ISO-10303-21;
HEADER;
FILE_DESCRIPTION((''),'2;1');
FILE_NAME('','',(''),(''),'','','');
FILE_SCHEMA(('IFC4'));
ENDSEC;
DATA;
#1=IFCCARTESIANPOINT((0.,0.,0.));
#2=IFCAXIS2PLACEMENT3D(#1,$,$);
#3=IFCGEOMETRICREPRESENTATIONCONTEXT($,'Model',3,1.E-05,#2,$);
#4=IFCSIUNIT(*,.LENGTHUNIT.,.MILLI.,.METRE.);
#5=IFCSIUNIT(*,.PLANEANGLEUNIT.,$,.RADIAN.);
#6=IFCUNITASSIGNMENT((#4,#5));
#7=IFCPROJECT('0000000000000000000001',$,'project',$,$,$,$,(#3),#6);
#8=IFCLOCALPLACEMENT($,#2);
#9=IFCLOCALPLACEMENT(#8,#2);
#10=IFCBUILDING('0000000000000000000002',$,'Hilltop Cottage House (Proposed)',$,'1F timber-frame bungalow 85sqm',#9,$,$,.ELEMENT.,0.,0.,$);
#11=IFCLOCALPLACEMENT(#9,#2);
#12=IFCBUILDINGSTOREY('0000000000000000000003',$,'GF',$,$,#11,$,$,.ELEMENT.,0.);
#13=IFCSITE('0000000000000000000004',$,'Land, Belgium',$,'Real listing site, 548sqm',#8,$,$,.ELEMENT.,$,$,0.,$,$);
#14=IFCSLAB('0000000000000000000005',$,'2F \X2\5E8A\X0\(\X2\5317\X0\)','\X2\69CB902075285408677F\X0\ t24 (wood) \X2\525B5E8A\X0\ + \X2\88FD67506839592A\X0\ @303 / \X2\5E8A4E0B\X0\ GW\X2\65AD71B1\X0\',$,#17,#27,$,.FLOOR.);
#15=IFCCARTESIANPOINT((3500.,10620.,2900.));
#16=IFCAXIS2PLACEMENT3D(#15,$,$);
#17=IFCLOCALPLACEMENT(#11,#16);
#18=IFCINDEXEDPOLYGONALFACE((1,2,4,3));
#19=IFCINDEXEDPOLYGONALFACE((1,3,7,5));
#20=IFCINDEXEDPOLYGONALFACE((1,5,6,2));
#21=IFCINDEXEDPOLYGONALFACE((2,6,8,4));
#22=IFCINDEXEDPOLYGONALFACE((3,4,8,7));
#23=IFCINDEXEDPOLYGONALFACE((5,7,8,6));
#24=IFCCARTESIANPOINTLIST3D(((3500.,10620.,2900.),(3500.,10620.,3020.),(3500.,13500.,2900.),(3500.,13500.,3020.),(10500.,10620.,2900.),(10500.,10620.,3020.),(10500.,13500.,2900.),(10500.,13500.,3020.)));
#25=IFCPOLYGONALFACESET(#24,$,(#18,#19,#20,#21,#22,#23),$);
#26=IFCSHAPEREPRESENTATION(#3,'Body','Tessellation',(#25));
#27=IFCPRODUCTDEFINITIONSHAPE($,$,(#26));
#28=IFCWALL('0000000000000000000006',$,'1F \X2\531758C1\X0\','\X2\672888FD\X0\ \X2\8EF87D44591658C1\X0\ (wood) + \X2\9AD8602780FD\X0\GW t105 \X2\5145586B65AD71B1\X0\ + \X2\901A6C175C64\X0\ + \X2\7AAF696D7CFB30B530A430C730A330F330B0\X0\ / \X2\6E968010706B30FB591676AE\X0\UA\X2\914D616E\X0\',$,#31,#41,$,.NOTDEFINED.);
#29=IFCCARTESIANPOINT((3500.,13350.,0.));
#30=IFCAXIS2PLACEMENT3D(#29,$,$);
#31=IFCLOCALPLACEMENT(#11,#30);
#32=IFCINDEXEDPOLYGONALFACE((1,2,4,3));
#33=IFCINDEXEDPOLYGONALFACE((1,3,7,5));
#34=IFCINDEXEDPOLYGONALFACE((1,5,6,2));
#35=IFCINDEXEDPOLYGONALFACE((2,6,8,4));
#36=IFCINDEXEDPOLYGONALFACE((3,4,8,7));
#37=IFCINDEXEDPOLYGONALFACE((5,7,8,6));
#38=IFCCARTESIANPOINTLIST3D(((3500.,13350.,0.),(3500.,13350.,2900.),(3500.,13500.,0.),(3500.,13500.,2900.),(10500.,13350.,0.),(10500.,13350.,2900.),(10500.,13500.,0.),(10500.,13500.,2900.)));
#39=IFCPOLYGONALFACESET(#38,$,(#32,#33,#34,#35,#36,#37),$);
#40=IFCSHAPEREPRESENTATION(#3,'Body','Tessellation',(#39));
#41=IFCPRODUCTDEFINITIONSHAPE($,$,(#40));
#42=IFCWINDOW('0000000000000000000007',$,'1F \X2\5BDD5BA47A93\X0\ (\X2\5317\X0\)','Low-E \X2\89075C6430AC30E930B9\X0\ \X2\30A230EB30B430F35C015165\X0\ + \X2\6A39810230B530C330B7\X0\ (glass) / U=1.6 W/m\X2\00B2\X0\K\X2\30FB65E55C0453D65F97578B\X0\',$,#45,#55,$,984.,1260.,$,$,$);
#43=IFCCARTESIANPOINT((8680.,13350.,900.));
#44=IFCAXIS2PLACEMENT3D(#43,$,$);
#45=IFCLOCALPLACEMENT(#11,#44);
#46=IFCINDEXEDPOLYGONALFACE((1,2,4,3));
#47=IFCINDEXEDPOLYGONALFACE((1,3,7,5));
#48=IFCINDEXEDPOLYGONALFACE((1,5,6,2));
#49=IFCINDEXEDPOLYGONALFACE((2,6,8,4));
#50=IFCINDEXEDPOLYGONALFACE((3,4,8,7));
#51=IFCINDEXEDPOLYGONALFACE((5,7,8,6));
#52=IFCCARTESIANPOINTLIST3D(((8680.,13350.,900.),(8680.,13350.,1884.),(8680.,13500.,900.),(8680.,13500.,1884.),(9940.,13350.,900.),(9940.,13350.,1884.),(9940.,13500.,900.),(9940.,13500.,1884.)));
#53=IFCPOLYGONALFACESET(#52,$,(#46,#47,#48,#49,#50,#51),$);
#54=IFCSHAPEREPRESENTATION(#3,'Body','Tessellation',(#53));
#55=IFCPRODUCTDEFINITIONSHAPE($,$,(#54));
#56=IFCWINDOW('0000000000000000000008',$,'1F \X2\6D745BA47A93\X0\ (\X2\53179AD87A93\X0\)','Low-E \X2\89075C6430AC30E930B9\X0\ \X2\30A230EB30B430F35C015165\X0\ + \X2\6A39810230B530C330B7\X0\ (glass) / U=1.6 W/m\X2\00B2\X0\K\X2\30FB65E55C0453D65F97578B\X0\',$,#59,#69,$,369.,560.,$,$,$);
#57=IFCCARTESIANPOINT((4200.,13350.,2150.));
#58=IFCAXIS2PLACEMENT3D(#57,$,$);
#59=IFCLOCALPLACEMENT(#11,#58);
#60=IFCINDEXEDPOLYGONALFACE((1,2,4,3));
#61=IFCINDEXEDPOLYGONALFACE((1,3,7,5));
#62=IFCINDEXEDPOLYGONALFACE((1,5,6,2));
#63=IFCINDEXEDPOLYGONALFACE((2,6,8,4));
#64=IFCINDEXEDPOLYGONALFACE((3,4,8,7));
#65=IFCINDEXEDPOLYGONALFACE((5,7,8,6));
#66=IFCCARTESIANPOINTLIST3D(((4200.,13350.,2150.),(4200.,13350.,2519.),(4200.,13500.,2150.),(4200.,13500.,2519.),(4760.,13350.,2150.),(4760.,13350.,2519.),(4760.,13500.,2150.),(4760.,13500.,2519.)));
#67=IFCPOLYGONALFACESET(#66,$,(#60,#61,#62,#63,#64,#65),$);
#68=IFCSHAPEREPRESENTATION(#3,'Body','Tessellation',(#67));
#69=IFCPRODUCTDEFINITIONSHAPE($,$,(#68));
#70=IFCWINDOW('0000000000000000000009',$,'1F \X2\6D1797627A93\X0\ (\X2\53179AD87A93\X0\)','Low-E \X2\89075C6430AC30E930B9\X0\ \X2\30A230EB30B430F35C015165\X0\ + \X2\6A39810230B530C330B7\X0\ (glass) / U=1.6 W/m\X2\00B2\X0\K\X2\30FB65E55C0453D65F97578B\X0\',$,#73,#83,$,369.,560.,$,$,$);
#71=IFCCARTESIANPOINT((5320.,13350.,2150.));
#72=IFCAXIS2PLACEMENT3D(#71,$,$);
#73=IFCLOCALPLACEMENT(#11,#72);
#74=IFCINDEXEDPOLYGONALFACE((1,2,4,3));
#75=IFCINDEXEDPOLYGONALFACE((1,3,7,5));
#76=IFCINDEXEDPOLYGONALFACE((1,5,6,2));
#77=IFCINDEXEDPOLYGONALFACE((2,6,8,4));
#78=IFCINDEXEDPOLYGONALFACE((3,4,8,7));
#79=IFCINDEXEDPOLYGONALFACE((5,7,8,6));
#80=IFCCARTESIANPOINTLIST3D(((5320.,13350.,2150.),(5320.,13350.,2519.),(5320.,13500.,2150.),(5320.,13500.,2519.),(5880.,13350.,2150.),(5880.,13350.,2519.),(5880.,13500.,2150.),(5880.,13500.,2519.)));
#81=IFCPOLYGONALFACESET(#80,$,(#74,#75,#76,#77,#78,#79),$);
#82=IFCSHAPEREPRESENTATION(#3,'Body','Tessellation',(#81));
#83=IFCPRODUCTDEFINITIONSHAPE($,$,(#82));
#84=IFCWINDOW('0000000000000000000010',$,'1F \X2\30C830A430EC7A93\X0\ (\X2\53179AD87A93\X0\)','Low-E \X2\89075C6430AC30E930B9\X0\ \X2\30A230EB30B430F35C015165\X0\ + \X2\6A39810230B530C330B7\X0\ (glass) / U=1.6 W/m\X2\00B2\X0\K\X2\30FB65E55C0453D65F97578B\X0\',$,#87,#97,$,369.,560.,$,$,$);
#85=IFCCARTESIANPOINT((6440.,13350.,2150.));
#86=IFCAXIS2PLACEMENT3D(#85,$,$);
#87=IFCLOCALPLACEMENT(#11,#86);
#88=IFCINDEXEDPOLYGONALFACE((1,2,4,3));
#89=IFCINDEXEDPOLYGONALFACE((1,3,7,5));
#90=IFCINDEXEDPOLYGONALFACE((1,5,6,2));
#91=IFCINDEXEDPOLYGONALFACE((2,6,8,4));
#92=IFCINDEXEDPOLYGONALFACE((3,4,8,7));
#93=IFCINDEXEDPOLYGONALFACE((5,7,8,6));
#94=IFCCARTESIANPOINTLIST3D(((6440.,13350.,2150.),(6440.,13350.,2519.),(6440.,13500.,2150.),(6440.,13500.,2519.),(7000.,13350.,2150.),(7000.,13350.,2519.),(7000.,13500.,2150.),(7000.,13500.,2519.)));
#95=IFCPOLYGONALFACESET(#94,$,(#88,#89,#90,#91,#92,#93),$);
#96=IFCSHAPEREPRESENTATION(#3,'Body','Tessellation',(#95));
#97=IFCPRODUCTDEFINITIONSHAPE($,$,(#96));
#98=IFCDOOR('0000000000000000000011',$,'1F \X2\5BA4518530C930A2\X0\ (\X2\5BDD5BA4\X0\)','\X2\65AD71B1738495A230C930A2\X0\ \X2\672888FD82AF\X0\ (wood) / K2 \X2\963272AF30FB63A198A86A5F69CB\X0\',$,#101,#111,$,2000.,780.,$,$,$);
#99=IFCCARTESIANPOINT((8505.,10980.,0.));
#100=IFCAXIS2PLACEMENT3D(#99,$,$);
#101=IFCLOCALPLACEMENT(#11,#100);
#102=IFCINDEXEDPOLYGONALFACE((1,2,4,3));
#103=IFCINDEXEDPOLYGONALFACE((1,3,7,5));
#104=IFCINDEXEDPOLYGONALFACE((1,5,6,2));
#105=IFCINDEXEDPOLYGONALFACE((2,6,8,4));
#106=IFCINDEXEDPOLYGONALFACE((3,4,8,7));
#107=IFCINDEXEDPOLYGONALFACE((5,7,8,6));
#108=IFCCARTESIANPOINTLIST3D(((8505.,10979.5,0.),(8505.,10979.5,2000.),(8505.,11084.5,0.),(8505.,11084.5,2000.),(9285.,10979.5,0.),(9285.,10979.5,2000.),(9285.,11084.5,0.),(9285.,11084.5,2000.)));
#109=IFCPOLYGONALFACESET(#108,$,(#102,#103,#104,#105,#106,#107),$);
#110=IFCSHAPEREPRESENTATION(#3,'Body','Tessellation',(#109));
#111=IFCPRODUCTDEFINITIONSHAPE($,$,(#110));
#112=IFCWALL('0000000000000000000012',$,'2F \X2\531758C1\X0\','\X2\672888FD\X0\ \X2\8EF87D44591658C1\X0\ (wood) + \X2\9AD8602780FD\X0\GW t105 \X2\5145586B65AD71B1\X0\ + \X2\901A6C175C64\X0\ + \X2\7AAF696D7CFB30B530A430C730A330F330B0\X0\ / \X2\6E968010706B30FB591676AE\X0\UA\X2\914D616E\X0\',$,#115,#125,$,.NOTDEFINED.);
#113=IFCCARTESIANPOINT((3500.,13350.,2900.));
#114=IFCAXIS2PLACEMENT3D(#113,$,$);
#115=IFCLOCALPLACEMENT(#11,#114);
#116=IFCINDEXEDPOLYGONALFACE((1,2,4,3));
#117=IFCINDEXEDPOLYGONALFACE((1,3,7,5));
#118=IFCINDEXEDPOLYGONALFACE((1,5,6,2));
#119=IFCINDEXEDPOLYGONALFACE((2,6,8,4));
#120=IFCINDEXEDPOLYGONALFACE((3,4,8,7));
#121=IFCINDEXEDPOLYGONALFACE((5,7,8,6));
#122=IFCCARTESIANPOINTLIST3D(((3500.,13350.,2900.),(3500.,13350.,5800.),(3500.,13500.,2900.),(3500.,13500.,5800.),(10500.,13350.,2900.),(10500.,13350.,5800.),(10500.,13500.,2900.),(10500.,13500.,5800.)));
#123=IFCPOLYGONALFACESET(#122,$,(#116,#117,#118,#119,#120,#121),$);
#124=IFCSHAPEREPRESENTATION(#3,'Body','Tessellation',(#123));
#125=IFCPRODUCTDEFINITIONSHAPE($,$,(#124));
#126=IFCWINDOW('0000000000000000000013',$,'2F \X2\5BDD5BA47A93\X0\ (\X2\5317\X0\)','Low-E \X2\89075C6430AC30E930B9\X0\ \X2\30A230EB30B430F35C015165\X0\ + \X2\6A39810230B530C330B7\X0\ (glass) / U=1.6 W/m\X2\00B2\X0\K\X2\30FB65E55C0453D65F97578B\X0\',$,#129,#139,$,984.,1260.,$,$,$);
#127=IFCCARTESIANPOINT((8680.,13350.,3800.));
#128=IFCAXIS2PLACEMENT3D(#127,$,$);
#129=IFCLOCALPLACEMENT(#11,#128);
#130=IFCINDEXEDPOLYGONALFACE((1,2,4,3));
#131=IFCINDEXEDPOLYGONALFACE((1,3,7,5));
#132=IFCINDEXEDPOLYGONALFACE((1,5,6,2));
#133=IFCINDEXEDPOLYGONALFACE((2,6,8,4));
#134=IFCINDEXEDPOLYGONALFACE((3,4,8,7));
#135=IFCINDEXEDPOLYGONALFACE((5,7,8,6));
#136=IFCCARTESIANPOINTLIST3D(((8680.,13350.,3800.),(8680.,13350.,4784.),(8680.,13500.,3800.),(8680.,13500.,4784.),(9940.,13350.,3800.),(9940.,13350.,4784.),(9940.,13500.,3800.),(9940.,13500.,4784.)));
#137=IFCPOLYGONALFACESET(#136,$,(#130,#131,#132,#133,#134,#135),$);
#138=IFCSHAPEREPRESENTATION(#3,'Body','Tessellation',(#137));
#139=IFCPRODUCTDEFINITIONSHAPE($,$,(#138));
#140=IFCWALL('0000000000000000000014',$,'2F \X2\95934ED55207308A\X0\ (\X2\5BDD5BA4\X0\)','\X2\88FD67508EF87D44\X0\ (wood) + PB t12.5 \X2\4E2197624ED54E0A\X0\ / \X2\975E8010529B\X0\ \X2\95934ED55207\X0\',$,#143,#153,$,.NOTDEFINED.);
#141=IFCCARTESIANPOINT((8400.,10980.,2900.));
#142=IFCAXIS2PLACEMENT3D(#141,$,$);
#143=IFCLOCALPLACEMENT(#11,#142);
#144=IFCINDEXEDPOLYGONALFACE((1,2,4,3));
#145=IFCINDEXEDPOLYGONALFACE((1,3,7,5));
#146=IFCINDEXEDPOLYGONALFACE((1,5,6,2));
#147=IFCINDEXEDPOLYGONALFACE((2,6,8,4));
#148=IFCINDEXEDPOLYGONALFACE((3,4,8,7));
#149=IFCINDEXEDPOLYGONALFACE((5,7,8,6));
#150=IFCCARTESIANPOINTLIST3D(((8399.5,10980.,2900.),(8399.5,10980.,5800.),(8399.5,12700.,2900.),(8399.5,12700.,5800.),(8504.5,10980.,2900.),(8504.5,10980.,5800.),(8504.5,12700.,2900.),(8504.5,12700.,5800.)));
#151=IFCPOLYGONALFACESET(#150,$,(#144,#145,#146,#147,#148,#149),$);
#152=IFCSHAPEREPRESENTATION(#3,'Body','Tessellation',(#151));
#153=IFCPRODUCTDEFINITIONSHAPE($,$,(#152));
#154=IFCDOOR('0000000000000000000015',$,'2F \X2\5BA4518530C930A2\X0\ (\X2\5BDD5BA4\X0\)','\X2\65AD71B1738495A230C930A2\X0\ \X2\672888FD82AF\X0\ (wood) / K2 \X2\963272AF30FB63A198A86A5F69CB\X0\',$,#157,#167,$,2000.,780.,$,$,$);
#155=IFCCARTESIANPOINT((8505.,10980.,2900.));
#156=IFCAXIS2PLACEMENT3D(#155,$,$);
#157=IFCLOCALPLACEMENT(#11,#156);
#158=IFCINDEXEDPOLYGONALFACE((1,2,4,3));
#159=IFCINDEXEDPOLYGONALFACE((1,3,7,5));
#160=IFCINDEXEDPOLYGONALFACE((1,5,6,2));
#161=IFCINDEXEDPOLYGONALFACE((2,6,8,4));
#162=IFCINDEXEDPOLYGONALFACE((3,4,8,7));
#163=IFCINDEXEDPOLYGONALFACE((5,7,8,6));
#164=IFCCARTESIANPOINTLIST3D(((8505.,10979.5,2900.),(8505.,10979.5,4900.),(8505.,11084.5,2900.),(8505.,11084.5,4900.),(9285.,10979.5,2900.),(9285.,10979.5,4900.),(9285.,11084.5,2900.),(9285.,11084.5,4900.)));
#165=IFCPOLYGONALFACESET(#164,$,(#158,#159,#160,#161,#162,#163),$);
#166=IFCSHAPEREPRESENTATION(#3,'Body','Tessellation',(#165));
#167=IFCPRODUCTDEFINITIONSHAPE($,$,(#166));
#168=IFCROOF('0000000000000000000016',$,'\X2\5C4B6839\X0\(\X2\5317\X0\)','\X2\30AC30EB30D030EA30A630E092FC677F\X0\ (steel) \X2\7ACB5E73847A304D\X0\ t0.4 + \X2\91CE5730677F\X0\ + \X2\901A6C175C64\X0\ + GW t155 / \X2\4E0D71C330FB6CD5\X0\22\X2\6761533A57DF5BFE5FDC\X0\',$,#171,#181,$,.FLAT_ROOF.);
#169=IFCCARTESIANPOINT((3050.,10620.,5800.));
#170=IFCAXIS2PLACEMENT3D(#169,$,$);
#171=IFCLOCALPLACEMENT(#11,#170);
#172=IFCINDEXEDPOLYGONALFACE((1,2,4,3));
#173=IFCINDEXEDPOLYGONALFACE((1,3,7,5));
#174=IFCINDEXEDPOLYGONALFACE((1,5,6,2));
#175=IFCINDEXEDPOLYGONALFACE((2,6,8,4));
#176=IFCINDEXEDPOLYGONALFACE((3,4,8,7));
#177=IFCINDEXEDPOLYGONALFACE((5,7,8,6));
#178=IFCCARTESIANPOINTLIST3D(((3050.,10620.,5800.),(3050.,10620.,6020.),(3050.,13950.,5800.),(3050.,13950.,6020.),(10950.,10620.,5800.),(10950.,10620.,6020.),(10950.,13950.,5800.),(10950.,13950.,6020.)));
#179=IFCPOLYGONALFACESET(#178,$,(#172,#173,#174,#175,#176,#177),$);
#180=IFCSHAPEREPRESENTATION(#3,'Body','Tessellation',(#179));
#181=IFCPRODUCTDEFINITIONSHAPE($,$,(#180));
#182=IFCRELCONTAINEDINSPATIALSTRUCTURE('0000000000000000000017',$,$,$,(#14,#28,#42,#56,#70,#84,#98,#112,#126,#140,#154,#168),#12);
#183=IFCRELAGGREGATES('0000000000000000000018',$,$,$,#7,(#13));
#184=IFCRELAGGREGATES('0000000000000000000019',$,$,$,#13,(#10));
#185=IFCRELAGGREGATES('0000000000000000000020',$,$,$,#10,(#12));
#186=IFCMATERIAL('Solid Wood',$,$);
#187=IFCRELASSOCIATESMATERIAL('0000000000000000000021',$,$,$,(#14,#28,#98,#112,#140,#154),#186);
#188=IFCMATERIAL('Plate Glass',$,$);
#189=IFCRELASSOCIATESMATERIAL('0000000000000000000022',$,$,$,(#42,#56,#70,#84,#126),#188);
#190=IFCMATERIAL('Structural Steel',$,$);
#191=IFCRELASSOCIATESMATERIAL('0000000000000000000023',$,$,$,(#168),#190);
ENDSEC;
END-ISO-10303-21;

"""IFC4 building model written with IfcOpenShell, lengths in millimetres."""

from ifc_helpers import new_model, si_unit, frame, frame_2d, origin, place, context, project, spatial, rectangle, extrude, material, element, fill, save


model = new_model("IFC4")

# Units and contexts
model_context = context("Model", 3, precision=1e-05, world=origin())
ifc_project = project(units=[si_unit("LENGTHUNIT", "METRE", prefix="MILLI"), si_unit("PLANEANGLEUNIT", "RADIAN")], contexts=[model_context])

# Site, building, storey
site_placement = place(None, origin())
site = spatial("IfcSite", under=ifc_project, at=site_placement, Name="Land, Belgium", ObjectType="Real listing site, 548sqm", CompositionType="ELEMENT", RefElevation=0.0)
building_placement = place(site_placement, origin())
building = spatial("IfcBuilding", under=site, at=building_placement, Name="Hilltop Cottage House (Proposed)", ObjectType="1F timber-frame bungalow 85sqm", CompositionType="ELEMENT", ElevationOfRefHeight=0.0, ElevationOfTerrain=0.0)
storey_placement = place(building_placement, origin())
storey = spatial("IfcBuildingStorey", under=building, at=storey_placement, Name="GF", CompositionType="ELEMENT", Elevation=0.0)

# Slab
ifc_material_1 = material(Name="Solid Wood")
slab_placement = place(storey_placement, frame((3500.0, 10620.0, 2900.0)))
element("IfcSlab", 1, at=slab_placement, inside=storey, material=ifc_material_1, Name="2F 床(北)", Description="構造用合板 t24 (wood) 剛床 + 製材根太 @303 / 床下 GW断熱", PredefinedType="FLOOR", context=model_context, shape_type="SweptSolid", body=[
    extrude(rectangle(XDim=7000.0, YDim=2880.0, at=frame_2d((3500.0, 1440.0))), frame((3500.0, 10620.0, 2900.0)), (0.0, 0.0, 1.0), 120.0),
])

# Wall, openings, windows
wall_1_placement = place(storey_placement, frame((3500.0, 13350.0, 0.0)))
wall_1 = element("IfcWall", 2, at=wall_1_placement, inside=storey, material=ifc_material_1, Name="1F 北壁", Description="木製 軸組外壁 (wood) + 高性能GW t105 充填断熱 + 通気層 + 窯業系サイディング / 準耐火・外皮UA配慮", PredefinedType="NOTDEFINED", context=model_context, shape_type="SweptSolid", body=[
    extrude(rectangle(XDim=7000.0, YDim=150.0, at=frame_2d((3500.0, 75.0))), frame((3500.0, 13350.0, 0.0)), (0.0, 0.0, 1.0), 2900.0),
])
opening_1_placement = place(storey_placement, frame((8680.0, 13350.0, 900.0)))
opening_1 = element("IfcOpeningElement", 3, at=opening_1_placement, cuts=wall_1, PredefinedType="NOTDEFINED", context=model_context, shape_type="SweptSolid", body=[
    extrude(rectangle(XDim=1260.0, YDim=150.0, at=frame_2d((630.0, 75.0))), frame((8680.0, 13350.0, 900.0)), (0.0, 0.0, 1.0), 984.0),
])
opening_2_placement = place(storey_placement, frame((4200.0, 13350.0, 2150.0)))
opening_2 = element("IfcOpeningElement", 4, at=opening_2_placement, cuts=wall_1, PredefinedType="NOTDEFINED", context=model_context, shape_type="SweptSolid", body=[
    extrude(rectangle(XDim=560.0, YDim=150.0, at=frame_2d((280.0, 75.0))), frame((4200.0, 13350.0, 2150.0)), (0.0, 0.0, 1.0), 369.0),
])
opening_3_placement = place(storey_placement, frame((5320.0, 13350.0, 2150.0)))
opening_3 = element("IfcOpeningElement", 5, at=opening_3_placement, cuts=wall_1, PredefinedType="NOTDEFINED", context=model_context, shape_type="SweptSolid", body=[
    extrude(rectangle(XDim=560.0, YDim=150.0, at=frame_2d((280.0, 75.0))), frame((5320.0, 13350.0, 2150.0)), (0.0, 0.0, 1.0), 369.0),
])
opening_4_placement = place(storey_placement, frame((6440.0, 13350.0, 2150.0)))
opening_4 = element("IfcOpeningElement", 6, at=opening_4_placement, cuts=wall_1, PredefinedType="NOTDEFINED", context=model_context, shape_type="SweptSolid", body=[
    extrude(rectangle(XDim=560.0, YDim=150.0, at=frame_2d((280.0, 75.0))), frame((6440.0, 13350.0, 2150.0)), (0.0, 0.0, 1.0), 369.0),
])
ifc_material_2 = material(Name="Plate Glass")
window_1_placement = place(storey_placement, frame((8680.0, 13350.0, 900.0)))
window_1 = element("IfcWindow", 7, at=window_1_placement, inside=storey, material=ifc_material_2, Name="1F 寝室窓 (北)", Description="Low-E 複層ガラス アルゴン封入 + 樹脂サッシ (glass) / U=1.6 W/m²K・日射取得型", OverallHeight=984.0, OverallWidth=1260.0, context=model_context, shape_type="SweptSolid", body=[
    extrude(rectangle(XDim=1260.0, YDim=150.0, at=frame_2d((630.0, 75.0))), frame((8680.0, 13350.0, 900.0)), (0.0, 0.0, 1.0), 984.0),
])
fill(opening_1, window_1)
window_2_placement = place(storey_placement, frame((4200.0, 13350.0, 2150.0)))
window_2 = element("IfcWindow", 8, at=window_2_placement, inside=storey, material=ifc_material_2, Name="1F 浴室窓 (北高窓)", Description="Low-E 複層ガラス アルゴン封入 + 樹脂サッシ (glass) / U=1.6 W/m²K・日射取得型", OverallHeight=369.0, OverallWidth=560.0, context=model_context, shape_type="SweptSolid", body=[
    extrude(rectangle(XDim=560.0, YDim=150.0, at=frame_2d((280.0, 75.0))), frame((4200.0, 13350.0, 2150.0)), (0.0, 0.0, 1.0), 369.0),
])
fill(opening_2, window_2)
window_3_placement = place(storey_placement, frame((5320.0, 13350.0, 2150.0)))
window_3 = element("IfcWindow", 9, at=window_3_placement, inside=storey, material=ifc_material_2, Name="1F 洗面窓 (北高窓)", Description="Low-E 複層ガラス アルゴン封入 + 樹脂サッシ (glass) / U=1.6 W/m²K・日射取得型", OverallHeight=369.0, OverallWidth=560.0, context=model_context, shape_type="SweptSolid", body=[
    extrude(rectangle(XDim=560.0, YDim=150.0, at=frame_2d((280.0, 75.0))), frame((5320.0, 13350.0, 2150.0)), (0.0, 0.0, 1.0), 369.0),
])
fill(opening_3, window_3)
window_4_placement = place(storey_placement, frame((6440.0, 13350.0, 2150.0)))
window_4 = element("IfcWindow", 10, at=window_4_placement, inside=storey, material=ifc_material_2, Name="1F トイレ窓 (北高窓)", Description="Low-E 複層ガラス アルゴン封入 + 樹脂サッシ (glass) / U=1.6 W/m²K・日射取得型", OverallHeight=369.0, OverallWidth=560.0, context=model_context, shape_type="SweptSolid", body=[
    extrude(rectangle(XDim=560.0, YDim=150.0, at=frame_2d((280.0, 75.0))), frame((6440.0, 13350.0, 2150.0)), (0.0, 0.0, 1.0), 369.0),
])
fill(opening_4, window_4)

# Door
door_1_placement = place(storey_placement, frame((8505.0, 10980.0, 0.0)))
element("IfcDoor", 11, at=door_1_placement, inside=storey, material=ifc_material_1, Name="1F 室内ドア (寝室)", Description="断熱玄関ドア 木製芯 (wood) / K2 防犯・採風機構", OverallHeight=2000.0, OverallWidth=780.0, context=model_context, shape_type="SweptSolid", body=[
    extrude(rectangle(XDim=780.0, YDim=105.0, at=frame_2d((390.0, 52.0))), frame((8505.0, 10980.0, 0.0)), (0.0, 0.0, 1.0), 2000.0),
])

# Wall, opening, window
wall_2_placement = place(storey_placement, frame((3500.0, 13350.0, 2900.0)))
wall_2 = element("IfcWall", 12, at=wall_2_placement, inside=storey, material=ifc_material_1, Name="2F 北壁", Description="木製 軸組外壁 (wood) + 高性能GW t105 充填断熱 + 通気層 + 窯業系サイディング / 準耐火・外皮UA配慮", PredefinedType="NOTDEFINED", context=model_context, shape_type="SweptSolid", body=[
    extrude(rectangle(XDim=7000.0, YDim=150.0, at=frame_2d((3500.0, 75.0))), frame((3500.0, 13350.0, 2900.0)), (0.0, 0.0, 1.0), 2900.0),
])
opening_5_placement = place(storey_placement, frame((8680.0, 13350.0, 3800.0)))
opening_5 = element("IfcOpeningElement", 13, at=opening_5_placement, cuts=wall_2, PredefinedType="NOTDEFINED", context=model_context, shape_type="SweptSolid", body=[
    extrude(rectangle(XDim=1260.0, YDim=150.0, at=frame_2d((630.0, 75.0))), frame((8680.0, 13350.0, 3800.0)), (0.0, 0.0, 1.0), 984.0),
])
window_5_placement = place(storey_placement, frame((8680.0, 13350.0, 3800.0)))
window_5 = element("IfcWindow", 14, at=window_5_placement, inside=storey, material=ifc_material_2, Name="2F 寝室窓 (北)", Description="Low-E 複層ガラス アルゴン封入 + 樹脂サッシ (glass) / U=1.6 W/m²K・日射取得型", OverallHeight=984.0, OverallWidth=1260.0, context=model_context, shape_type="SweptSolid", body=[
    extrude(rectangle(XDim=1260.0, YDim=150.0, at=frame_2d((630.0, 75.0))), frame((8680.0, 13350.0, 3800.0)), (0.0, 0.0, 1.0), 984.0),
])
fill(opening_5, window_5)

# Wall
wall_3_placement = place(storey_placement, frame((8400.0, 10980.0, 2900.0)))
element("IfcWall", 15, at=wall_3_placement, inside=storey, material=ifc_material_1, Name="2F 間仕切り (寝室)", Description="製材軸組 (wood) + PB t12.5 両面仕上 / 非耐力 間仕切", PredefinedType="NOTDEFINED", context=model_context, shape_type="SweptSolid", body=[
    extrude(rectangle(XDim=105.0, YDim=1720.0, at=frame_2d((52.0, 860.0))), frame((8400.0, 10980.0, 2900.0)), (0.0, 0.0, 1.0), 2900.0),
])

# Door
door_2_placement = place(storey_placement, frame((8505.0, 10980.0, 2900.0)))
element("IfcDoor", 16, at=door_2_placement, inside=storey, material=ifc_material_1, Name="2F 室内ドア (寝室)", Description="断熱玄関ドア 木製芯 (wood) / K2 防犯・採風機構", OverallHeight=2000.0, OverallWidth=780.0, context=model_context, shape_type="SweptSolid", body=[
    extrude(rectangle(XDim=780.0, YDim=105.0, at=frame_2d((390.0, 52.0))), frame((8505.0, 10980.0, 2900.0)), (0.0, 0.0, 1.0), 2000.0),
])

# Roof
ifc_material_3 = material(Name="Structural Steel")
roof_placement = place(storey_placement, frame((3050.0, 10620.0, 5800.0)))
element("IfcRoof", 17, at=roof_placement, inside=storey, material=ifc_material_3, Name="屋根(北)", Description="ガルバリウム鋼板 (steel) 立平葺き t0.4 + 野地板 + 通気層 + GW t155 / 不燃・法22条区域対応", PredefinedType="FLAT_ROOF", context=model_context, shape_type="SweptSolid", body=[
    extrude(rectangle(XDim=7900.0, YDim=3330.0, at=frame_2d((3950.0, 1665.0))), frame((3050.0, 10620.0, 5800.0)), (0.0, 0.0, 1.0), 220.0),
])

save(model, "model.ifc")
